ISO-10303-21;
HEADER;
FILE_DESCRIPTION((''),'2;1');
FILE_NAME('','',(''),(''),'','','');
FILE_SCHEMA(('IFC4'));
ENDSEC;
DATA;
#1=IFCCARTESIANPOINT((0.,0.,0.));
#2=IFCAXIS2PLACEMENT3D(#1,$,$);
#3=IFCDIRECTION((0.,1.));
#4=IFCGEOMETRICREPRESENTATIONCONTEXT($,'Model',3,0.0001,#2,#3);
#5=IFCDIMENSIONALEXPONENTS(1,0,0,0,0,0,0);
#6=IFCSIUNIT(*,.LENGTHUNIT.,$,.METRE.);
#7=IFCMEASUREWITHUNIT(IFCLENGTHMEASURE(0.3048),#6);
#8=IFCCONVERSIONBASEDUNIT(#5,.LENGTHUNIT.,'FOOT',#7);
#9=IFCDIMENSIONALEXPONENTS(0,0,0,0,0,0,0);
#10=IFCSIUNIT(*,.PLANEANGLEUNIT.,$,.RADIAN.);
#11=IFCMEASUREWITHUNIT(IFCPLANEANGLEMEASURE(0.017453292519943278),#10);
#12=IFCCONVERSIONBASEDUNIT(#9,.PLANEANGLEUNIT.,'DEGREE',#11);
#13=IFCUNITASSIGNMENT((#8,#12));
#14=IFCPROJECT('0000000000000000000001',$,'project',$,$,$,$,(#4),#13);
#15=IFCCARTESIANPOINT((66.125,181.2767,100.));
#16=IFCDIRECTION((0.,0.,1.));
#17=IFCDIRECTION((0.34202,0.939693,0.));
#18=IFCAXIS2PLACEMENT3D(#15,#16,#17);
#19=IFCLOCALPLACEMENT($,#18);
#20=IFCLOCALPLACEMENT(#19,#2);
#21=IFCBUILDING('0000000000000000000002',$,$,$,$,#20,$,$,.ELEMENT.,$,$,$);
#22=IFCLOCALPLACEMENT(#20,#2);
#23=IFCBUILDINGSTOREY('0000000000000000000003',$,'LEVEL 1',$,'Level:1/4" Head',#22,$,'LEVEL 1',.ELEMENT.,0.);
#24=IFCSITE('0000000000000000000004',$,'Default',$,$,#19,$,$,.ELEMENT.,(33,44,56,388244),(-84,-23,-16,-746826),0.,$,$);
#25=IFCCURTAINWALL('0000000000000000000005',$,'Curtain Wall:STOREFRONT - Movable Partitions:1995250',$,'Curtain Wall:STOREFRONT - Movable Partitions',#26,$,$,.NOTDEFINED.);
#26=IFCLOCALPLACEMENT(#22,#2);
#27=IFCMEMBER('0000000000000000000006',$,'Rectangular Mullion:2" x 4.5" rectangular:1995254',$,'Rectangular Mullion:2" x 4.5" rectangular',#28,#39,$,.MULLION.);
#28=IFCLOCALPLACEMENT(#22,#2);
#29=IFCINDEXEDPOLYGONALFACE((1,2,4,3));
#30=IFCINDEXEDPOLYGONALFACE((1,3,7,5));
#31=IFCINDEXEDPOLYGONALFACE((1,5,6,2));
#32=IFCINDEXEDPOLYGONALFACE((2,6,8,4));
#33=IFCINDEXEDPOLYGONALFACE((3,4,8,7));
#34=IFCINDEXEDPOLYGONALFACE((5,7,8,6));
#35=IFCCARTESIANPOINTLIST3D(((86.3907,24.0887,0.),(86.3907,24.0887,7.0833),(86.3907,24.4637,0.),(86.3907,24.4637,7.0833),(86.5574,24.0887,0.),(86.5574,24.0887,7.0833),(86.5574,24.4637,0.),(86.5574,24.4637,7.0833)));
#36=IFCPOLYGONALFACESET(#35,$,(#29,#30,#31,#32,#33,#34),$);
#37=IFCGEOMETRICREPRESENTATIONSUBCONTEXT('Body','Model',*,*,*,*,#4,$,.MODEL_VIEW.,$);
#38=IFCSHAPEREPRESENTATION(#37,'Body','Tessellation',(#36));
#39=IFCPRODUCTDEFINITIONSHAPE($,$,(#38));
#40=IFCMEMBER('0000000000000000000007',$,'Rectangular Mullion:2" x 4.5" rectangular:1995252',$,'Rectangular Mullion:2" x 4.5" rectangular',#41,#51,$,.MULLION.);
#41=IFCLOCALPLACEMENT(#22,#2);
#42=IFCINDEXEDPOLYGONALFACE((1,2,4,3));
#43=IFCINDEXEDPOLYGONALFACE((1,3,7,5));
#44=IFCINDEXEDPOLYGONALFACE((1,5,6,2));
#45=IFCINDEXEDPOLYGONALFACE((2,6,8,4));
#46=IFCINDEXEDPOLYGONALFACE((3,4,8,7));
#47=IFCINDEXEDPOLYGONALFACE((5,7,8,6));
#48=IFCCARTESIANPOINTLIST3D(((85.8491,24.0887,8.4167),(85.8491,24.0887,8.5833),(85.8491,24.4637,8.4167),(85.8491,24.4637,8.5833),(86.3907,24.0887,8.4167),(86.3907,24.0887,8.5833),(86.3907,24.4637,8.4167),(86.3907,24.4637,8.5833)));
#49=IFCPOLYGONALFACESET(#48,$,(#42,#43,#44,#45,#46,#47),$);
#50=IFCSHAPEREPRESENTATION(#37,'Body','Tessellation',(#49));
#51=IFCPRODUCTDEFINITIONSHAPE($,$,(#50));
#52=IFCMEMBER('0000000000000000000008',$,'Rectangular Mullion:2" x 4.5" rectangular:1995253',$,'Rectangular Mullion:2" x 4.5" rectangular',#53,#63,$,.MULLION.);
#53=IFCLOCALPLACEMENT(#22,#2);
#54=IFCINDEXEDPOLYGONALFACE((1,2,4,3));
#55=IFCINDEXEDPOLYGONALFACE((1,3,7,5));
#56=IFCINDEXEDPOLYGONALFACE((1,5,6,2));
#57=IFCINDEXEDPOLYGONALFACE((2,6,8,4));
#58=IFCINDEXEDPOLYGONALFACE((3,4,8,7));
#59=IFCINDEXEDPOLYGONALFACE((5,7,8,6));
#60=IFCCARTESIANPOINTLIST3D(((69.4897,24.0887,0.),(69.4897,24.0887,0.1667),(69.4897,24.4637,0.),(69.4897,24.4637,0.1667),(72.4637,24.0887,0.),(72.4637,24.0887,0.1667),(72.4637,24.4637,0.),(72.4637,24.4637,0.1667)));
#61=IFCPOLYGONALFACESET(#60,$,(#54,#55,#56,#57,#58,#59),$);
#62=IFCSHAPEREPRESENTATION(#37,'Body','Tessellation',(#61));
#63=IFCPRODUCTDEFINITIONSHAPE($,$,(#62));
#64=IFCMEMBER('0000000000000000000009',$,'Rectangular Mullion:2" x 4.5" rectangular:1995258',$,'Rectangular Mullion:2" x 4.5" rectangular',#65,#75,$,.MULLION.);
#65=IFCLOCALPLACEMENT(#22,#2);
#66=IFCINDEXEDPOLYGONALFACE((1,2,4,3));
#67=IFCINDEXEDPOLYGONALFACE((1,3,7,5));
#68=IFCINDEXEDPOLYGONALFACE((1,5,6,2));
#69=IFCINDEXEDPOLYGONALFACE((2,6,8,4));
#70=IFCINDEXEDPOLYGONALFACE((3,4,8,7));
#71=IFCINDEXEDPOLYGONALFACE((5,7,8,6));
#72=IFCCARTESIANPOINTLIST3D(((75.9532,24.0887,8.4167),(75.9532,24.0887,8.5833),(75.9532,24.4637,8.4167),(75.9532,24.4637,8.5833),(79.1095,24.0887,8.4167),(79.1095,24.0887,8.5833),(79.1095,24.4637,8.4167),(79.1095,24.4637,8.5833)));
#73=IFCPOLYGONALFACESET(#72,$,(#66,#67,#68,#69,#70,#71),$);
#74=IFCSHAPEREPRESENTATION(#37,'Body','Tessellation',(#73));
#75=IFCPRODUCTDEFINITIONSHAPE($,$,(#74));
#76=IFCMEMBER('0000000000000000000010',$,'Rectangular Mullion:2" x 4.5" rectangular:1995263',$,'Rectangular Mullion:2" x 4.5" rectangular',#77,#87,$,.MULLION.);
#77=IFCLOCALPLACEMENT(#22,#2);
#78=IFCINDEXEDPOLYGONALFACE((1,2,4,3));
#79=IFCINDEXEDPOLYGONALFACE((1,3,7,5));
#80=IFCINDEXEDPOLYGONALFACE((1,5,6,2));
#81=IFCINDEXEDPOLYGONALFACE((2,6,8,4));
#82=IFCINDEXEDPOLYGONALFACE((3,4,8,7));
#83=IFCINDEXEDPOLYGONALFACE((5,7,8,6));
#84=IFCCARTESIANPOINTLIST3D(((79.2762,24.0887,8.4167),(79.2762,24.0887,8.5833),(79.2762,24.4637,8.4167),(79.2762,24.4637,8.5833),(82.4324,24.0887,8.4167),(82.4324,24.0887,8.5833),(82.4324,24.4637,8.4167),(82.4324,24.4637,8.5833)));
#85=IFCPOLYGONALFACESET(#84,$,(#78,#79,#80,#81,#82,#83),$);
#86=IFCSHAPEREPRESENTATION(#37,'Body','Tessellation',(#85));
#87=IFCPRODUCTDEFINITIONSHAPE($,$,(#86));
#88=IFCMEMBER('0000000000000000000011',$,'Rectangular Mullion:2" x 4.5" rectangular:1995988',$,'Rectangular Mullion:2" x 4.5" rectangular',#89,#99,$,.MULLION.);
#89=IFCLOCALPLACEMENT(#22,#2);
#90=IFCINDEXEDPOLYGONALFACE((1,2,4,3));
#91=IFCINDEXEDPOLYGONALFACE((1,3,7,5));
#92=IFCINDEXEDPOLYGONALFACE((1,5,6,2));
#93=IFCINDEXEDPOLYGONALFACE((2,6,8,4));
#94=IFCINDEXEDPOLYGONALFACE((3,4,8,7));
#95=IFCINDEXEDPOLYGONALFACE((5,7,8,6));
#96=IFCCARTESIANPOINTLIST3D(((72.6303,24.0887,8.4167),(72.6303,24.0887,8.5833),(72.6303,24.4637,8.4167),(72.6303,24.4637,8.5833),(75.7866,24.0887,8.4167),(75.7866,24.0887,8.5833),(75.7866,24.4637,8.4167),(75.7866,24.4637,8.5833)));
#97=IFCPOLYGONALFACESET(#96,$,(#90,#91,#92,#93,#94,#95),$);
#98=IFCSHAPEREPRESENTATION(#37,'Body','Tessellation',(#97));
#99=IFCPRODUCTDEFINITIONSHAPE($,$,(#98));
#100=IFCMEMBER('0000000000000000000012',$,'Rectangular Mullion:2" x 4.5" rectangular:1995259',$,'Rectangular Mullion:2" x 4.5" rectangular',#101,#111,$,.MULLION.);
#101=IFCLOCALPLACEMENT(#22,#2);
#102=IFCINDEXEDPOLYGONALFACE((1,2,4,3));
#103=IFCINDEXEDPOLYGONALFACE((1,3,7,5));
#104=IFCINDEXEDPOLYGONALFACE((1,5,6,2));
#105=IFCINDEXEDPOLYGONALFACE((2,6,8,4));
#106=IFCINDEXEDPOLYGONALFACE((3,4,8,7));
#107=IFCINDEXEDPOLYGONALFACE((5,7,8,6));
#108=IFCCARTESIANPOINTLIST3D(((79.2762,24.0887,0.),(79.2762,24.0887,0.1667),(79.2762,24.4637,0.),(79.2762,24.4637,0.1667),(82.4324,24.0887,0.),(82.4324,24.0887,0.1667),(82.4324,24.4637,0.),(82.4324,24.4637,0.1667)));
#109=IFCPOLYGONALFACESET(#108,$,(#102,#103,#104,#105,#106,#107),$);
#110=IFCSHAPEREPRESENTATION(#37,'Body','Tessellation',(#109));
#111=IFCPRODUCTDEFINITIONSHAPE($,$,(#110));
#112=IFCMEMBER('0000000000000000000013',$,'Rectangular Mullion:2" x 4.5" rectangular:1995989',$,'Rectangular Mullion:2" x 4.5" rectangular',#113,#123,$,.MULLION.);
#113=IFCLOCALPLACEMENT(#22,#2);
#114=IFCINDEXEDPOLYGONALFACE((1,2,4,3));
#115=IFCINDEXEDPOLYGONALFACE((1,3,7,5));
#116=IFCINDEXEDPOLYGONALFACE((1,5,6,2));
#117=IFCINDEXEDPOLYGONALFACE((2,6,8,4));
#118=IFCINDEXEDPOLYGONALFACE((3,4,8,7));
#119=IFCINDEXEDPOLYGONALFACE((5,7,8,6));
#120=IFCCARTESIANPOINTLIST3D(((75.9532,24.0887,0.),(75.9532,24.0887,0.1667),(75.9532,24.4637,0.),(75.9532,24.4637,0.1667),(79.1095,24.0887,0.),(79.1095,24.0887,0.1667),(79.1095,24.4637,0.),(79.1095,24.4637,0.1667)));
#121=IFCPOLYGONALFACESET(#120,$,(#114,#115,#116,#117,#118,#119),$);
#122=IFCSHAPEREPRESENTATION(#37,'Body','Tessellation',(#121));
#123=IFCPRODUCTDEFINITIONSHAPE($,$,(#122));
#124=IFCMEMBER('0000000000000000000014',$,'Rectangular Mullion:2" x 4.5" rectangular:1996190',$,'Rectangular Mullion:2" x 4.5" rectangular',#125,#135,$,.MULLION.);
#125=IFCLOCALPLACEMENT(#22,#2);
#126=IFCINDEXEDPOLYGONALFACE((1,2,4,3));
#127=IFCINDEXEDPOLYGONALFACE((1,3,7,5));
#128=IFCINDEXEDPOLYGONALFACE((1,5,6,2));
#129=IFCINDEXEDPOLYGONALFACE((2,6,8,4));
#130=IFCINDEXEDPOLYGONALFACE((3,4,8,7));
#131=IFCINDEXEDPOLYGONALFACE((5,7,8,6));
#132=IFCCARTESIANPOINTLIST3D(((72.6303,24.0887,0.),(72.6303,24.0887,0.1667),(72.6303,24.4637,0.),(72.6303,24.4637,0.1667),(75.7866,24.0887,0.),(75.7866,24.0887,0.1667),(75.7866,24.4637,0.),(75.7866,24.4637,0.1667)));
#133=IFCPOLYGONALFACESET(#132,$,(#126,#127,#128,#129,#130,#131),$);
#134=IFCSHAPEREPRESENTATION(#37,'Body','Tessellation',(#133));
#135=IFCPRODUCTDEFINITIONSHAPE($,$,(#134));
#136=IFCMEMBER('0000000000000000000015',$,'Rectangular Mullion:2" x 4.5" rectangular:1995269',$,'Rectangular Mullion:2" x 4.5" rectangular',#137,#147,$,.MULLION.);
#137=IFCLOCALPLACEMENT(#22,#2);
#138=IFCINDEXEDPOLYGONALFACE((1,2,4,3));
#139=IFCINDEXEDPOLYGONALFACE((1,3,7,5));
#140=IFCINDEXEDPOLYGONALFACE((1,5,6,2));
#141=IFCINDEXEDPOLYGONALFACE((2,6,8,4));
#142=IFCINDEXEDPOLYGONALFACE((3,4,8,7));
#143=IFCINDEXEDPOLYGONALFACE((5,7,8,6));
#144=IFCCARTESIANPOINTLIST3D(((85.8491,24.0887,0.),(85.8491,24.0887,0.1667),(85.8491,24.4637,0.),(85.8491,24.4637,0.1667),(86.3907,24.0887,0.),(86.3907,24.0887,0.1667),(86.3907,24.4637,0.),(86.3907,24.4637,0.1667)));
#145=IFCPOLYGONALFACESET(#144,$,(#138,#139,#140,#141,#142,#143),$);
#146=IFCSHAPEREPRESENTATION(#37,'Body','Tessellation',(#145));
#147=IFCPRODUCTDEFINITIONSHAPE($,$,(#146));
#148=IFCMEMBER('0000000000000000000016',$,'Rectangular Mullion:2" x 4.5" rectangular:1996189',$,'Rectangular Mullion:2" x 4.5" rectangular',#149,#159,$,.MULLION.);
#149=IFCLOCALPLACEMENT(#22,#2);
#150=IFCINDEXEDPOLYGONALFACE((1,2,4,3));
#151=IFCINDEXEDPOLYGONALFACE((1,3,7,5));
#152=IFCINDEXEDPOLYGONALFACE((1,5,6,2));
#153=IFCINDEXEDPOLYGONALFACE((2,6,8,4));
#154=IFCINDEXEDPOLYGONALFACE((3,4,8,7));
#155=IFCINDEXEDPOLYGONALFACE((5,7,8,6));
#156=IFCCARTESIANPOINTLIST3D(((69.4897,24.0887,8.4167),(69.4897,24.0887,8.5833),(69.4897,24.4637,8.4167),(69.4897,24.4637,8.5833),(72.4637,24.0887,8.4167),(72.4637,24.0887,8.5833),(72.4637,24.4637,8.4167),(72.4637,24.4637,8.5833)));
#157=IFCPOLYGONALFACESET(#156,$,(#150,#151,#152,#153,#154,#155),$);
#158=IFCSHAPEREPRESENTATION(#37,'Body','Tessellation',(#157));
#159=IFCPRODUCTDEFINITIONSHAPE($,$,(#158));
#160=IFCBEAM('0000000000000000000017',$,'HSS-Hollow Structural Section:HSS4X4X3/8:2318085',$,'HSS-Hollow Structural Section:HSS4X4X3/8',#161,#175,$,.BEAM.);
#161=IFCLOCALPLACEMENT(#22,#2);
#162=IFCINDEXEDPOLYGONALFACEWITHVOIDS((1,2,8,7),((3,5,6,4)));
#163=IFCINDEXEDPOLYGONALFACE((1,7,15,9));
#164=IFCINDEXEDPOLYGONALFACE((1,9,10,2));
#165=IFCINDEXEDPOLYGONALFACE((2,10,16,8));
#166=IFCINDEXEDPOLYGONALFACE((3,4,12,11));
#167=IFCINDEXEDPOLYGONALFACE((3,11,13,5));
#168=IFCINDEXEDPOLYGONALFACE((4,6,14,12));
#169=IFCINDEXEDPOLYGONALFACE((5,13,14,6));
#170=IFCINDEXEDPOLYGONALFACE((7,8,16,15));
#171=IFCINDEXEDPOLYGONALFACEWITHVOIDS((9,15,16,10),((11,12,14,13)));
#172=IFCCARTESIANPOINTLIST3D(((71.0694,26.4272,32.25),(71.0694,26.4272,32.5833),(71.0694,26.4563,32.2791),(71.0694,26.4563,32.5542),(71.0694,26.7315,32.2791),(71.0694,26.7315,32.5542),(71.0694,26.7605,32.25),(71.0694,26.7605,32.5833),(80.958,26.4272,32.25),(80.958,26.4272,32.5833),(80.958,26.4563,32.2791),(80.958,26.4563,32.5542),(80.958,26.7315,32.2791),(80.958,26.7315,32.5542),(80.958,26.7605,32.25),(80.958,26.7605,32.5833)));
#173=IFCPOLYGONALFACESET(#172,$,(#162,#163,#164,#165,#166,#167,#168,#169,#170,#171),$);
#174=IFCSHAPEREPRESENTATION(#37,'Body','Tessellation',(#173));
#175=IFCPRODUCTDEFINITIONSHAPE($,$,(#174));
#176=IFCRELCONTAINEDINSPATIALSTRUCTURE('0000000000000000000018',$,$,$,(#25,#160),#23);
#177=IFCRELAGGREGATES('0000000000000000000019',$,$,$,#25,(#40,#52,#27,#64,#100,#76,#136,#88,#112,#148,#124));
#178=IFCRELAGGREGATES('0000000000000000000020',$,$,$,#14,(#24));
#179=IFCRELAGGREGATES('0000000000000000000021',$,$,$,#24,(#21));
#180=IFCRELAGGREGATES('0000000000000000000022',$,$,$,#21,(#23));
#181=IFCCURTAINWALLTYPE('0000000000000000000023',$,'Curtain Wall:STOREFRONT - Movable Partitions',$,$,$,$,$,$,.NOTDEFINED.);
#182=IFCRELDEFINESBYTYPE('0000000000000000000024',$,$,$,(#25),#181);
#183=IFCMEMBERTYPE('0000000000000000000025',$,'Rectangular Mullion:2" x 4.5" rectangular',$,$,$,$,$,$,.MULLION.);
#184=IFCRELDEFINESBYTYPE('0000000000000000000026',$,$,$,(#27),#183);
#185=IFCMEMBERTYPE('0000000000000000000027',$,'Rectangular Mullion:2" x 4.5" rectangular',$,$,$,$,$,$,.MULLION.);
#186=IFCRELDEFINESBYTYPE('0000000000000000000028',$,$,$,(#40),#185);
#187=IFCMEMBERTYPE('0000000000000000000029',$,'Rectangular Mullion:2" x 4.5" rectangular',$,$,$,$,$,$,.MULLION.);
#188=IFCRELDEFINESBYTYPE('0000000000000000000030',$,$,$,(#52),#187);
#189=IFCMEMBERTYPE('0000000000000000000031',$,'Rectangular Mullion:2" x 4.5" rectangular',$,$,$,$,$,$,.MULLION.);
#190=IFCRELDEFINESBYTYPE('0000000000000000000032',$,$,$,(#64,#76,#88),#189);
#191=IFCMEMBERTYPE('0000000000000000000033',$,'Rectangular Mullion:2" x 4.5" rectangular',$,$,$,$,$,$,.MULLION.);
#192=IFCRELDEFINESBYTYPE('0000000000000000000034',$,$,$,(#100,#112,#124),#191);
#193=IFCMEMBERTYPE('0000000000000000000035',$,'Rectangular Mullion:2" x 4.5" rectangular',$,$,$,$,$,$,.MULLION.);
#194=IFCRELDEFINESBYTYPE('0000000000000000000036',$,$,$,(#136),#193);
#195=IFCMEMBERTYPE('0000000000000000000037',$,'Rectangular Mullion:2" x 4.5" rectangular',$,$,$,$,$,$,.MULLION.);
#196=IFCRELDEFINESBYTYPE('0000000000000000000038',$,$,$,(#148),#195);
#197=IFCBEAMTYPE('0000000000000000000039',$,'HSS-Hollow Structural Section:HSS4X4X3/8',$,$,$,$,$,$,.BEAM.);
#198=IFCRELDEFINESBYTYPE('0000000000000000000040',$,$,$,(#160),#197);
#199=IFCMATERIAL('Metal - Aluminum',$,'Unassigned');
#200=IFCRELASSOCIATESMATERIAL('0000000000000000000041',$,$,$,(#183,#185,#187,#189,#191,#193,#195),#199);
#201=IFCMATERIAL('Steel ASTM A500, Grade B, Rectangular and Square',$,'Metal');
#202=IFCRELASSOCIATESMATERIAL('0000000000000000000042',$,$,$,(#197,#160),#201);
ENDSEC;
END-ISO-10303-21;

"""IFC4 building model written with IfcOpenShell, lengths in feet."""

from ifc_helpers import new_model, entity, si_unit, converted_unit, direction, frame, frame_2d, origin, origin_2d_with_axis, place, context, subcontext, project, spatial, rectangle, extrude, boolean, source, transform, mapped, material, material_profile, profile_set, type_object, type_shapes, element, aggregate, save


model = new_model("IFC4")

# Units and contexts
model_context = context("Model", 3, precision=0.0001, world=origin(), true_north=direction((0.0, 1.0)))
body_context = subcontext(model_context, "Body", "Model", "MODEL_VIEW")
ifc_project = project(units=[converted_unit("LENGTHUNIT", "FOOT", entity("IfcLengthMeasure", 0.3048), si_unit("LENGTHUNIT", "METRE"), dimensions=[1, 0, 0, 0, 0, 0, 0]), converted_unit("PLANEANGLEUNIT", "DEGREE", entity("IfcPlaneAngleMeasure", 0.017453292519943278), si_unit("PLANEANGLEUNIT", "RADIAN"), dimensions=[0, 0, 0, 0, 0, 0, 0])], contexts=[model_context])

# Site, building, storey
site_placement = place(None, frame((66.125, 181.2767, 100.0), z_axis=(0.0, 0.0, 1.0), x_axis=(0.34202, 0.939693, 0.0)))
site = spatial("IfcSite", under=ifc_project, at=site_placement, Name="Default", CompositionType="ELEMENT", RefLatitude=(33, 44, 56, 388244), RefLongitude=(-84, -23, -16, -746826), RefElevation=0.0)
building_placement = place(site_placement, origin())
building = spatial("IfcBuilding", under=site, at=building_placement, CompositionType="ELEMENT")
storey_placement = place(building_placement, origin())
storey = spatial("IfcBuildingStorey", under=building, at=storey_placement, Name="LEVEL 1", ObjectType="Level:1/4\" Head", LongName="LEVEL 1", CompositionType="ELEMENT", Elevation=0.0)

# Curtain wall, members
curtain_wall_type = type_object("IfcCurtainWallType", Name="Curtain Wall:STOREFRONT - Movable Partitions", PredefinedType="NOTDEFINED")
curtain_wall_1_placement = place(storey_placement, origin())
curtain_wall_1 = element("IfcCurtainWall", 1, at=curtain_wall_1_placement, inside=storey, type_object=curtain_wall_type, Name="Curtain Wall:STOREFRONT - Movable Partitions:1995250", ObjectType="Curtain Wall:STOREFRONT - Movable Partitions", PredefinedType="NOTDEFINED")
ifc_material_1 = material(Name="Metal - Aluminum", Category="Unassigned")
ifc_material_profile_1 = material_profile(ifc_material_1, rectangle(XDim=0.1667, YDim=0.375, at=origin_2d_with_axis()), Name="2\" x 4.5\" rectangular")
ifc_profile_set_1 = profile_set([ifc_material_profile_1], Name="2\" x 4.5\" rectangular")
member_type_1 = type_object("IfcMemberType", Name="Rectangular Mullion:2\" x 4.5\" rectangular", PredefinedType="MULLION", material=ifc_profile_set_1)
shared_shape_1 = source(origin(), body_context, "Body", "SweptSolid", [
    extrude(rectangle(XDim=0.1667, YDim=0.375, at=origin_2d_with_axis()), frame((-0.0833, 0.0, -7.0833), z_axis=(0.0, 0.0, 1.0), x_axis=(-1.0, 0.0, 0.0)), (0.0, 0.0, 1.0), 7.0833),
])
type_shapes(member_type_1, [shared_shape_1])
member_1_placement = place(curtain_wall_1_placement, frame((86.5574, 24.2762, 0.0), z_axis=(0.0, 0.0, -1.0), x_axis=(1.0, 0.0, 0.0)))
member_1 = element("IfcMember", 2, at=member_1_placement, type_object=member_type_1, Name="Rectangular Mullion:2\" x 4.5\" rectangular:1995254", ObjectType="Rectangular Mullion:2\" x 4.5\" rectangular", PredefinedType="MULLION", context=body_context, shape_type="MappedRepresentation", body=[
    mapped(shared_shape_1, transform((0.0, 0.0, 0.0), scale=1.0)),
])
member_type_2 = type_object("IfcMemberType", Name="Rectangular Mullion:2\" x 4.5\" rectangular", PredefinedType="MULLION", material=ifc_profile_set_1)
shared_shape_2 = source(origin(), body_context, "Body", "SweptSolid", [
    extrude(rectangle(XDim=0.1667, YDim=0.375, at=origin_2d_with_axis()), frame((-0.0833, 0.0, -0.5417), z_axis=(0.0, 0.0, 1.0), x_axis=(-1.0, 0.0, 0.0)), (0.0, 0.0, 1.0), 0.5417),
])
type_shapes(member_type_2, [shared_shape_2])
member_2_placement = place(curtain_wall_1_placement, frame((86.3907, 24.2762, 8.5833), z_axis=(1.0, 0.0, 0.0), x_axis=(0.0, 0.0, 1.0)))
member_2 = element("IfcMember", 3, at=member_2_placement, type_object=member_type_2, Name="Rectangular Mullion:2\" x 4.5\" rectangular:1995252", ObjectType="Rectangular Mullion:2\" x 4.5\" rectangular", PredefinedType="MULLION", context=body_context, shape_type="MappedRepresentation", body=[
    mapped(shared_shape_2, transform((0.0, 0.0, 0.0), scale=1.0)),
])
member_type_3 = type_object("IfcMemberType", Name="Rectangular Mullion:2\" x 4.5\" rectangular", PredefinedType="MULLION", material=ifc_profile_set_1)
shared_shape_3 = source(origin(), body_context, "Body", "SweptSolid", [
    extrude(rectangle(XDim=0.1667, YDim=0.375, at=origin_2d_with_axis()), frame((-0.0833, 0.0, -2.974), z_axis=(0.0, 0.0, 1.0), x_axis=(-1.0, 0.0, 0.0)), (0.0, 0.0, 1.0), 2.974),
])
type_shapes(member_type_3, [shared_shape_3])
member_3_placement = place(curtain_wall_1_placement, frame((69.4897, 24.2762, 0.0), z_axis=(-1.0, 0.0, 0.0), x_axis=(0.0, 0.0, -1.0)))
member_3 = element("IfcMember", 4, at=member_3_placement, type_object=member_type_3, Name="Rectangular Mullion:2\" x 4.5\" rectangular:1995253", ObjectType="Rectangular Mullion:2\" x 4.5\" rectangular", PredefinedType="MULLION", context=body_context, shape_type="MappedRepresentation", body=[
    mapped(shared_shape_3, transform((0.0, 0.0, 0.0), scale=1.0)),
])
member_type_4 = type_object("IfcMemberType", Name="Rectangular Mullion:2\" x 4.5\" rectangular", PredefinedType="MULLION", material=ifc_profile_set_1)
shared_shape_4 = source(origin(), body_context, "Body", "SweptSolid", [
    extrude(rectangle(XDim=0.1667, YDim=0.375, at=origin_2d_with_axis()), frame((-0.0833, 0.0, -3.1563), z_axis=(0.0, 0.0, 1.0), x_axis=(-1.0, 0.0, 0.0)), (0.0, 0.0, 1.0), 3.1563),
])
type_shapes(member_type_4, [shared_shape_4])
member_4_placement = place(curtain_wall_1_placement, frame((79.1095, 24.2762, 8.5833), z_axis=(1.0, 0.0, 0.0), x_axis=(0.0, 0.0, 1.0)))
member_4 = element("IfcMember", 5, at=member_4_placement, type_object=member_type_4, Name="Rectangular Mullion:2\" x 4.5\" rectangular:1995258", ObjectType="Rectangular Mullion:2\" x 4.5\" rectangular", PredefinedType="MULLION", context=body_context, shape_type="MappedRepresentation", body=[
    mapped(shared_shape_4, transform((0.0, 0.0, 0.0), scale=1.0)),
])
member_5_placement = place(curtain_wall_1_placement, frame((82.4324, 24.2762, 8.5833), z_axis=(1.0, 0.0, 0.0), x_axis=(0.0, 0.0, 1.0)))
member_5 = element("IfcMember", 6, at=member_5_placement, type_object=member_type_4, Name="Rectangular Mullion:2\" x 4.5\" rectangular:1995263", ObjectType="Rectangular Mullion:2\" x 4.5\" rectangular", PredefinedType="MULLION", context=body_context, shape_type="MappedRepresentation", body=[
    mapped(shared_shape_4, transform((0.0, 0.0, 0.0), scale=1.0)),
])
member_6_placement = place(curtain_wall_1_placement, frame((75.7866, 24.2762, 8.5833), z_axis=(1.0, 0.0, 0.0), x_axis=(0.0, 0.0, 1.0)))
member_6 = element("IfcMember", 7, at=member_6_placement, type_object=member_type_4, Name="Rectangular Mullion:2\" x 4.5\" rectangular:1995988", ObjectType="Rectangular Mullion:2\" x 4.5\" rectangular", PredefinedType="MULLION", context=body_context, shape_type="MappedRepresentation", body=[
    mapped(shared_shape_4, transform((0.0, 0.0, 0.0), scale=1.0)),
])
member_type_5 = type_object("IfcMemberType", Name="Rectangular Mullion:2\" x 4.5\" rectangular", PredefinedType="MULLION", material=ifc_profile_set_1)
shared_shape_5 = source(origin(), body_context, "Body", "SweptSolid", [
    extrude(rectangle(XDim=0.1667, YDim=0.375, at=origin_2d_with_axis()), frame((-0.0833, 0.0, -3.1563), z_axis=(0.0, 0.0, 1.0), x_axis=(-1.0, 0.0, 0.0)), (0.0, 0.0, 1.0), 3.1563),
])
type_shapes(member_type_5, [shared_shape_5])
member_7_placement = place(curtain_wall_1_placement, frame((79.2762, 24.2762, 0.0), z_axis=(-1.0, 0.0, 0.0), x_axis=(0.0, 0.0, -1.0)))
member_7 = element("IfcMember", 8, at=member_7_placement, type_object=member_type_5, Name="Rectangular Mullion:2\" x 4.5\" rectangular:1995259", ObjectType="Rectangular Mullion:2\" x 4.5\" rectangular", PredefinedType="MULLION", context=body_context, shape_type="MappedRepresentation", body=[
    mapped(shared_shape_5, transform((0.0, 0.0, 0.0), scale=1.0)),
])
member_8_placement = place(curtain_wall_1_placement, frame((75.9532, 24.2762, 0.0), z_axis=(-1.0, 0.0, 0.0), x_axis=(0.0, 0.0, -1.0)))
member_8 = element("IfcMember", 9, at=member_8_placement, type_object=member_type_5, Name="Rectangular Mullion:2\" x 4.5\" rectangular:1995989", ObjectType="Rectangular Mullion:2\" x 4.5\" rectangular", PredefinedType="MULLION", context=body_context, shape_type="MappedRepresentation", body=[
    mapped(shared_shape_5, transform((0.0, 0.0, 0.0), scale=1.0)),
])
member_9_placement = place(curtain_wall_1_placement, frame((72.6303, 24.2762, 0.0), z_axis=(-1.0, 0.0, 0.0), x_axis=(0.0, 0.0, -1.0)))
member_9 = element("IfcMember", 10, at=member_9_placement, type_object=member_type_5, Name="Rectangular Mullion:2\" x 4.5\" rectangular:1996190", ObjectType="Rectangular Mullion:2\" x 4.5\" rectangular", PredefinedType="MULLION", context=body_context, shape_type="MappedRepresentation", body=[
    mapped(shared_shape_5, transform((0.0, 0.0, 0.0), scale=1.0)),
])
member_type_6 = type_object("IfcMemberType", Name="Rectangular Mullion:2\" x 4.5\" rectangular", PredefinedType="MULLION", material=ifc_profile_set_1)
shared_shape_6 = source(origin(), body_context, "Body", "SweptSolid", [
    extrude(rectangle(XDim=0.1667, YDim=0.375, at=origin_2d_with_axis()), frame((-0.0833, 0.0, -0.5417), z_axis=(0.0, 0.0, 1.0), x_axis=(-1.0, 0.0, 0.0)), (0.0, 0.0, 1.0), 0.5417),
])
type_shapes(member_type_6, [shared_shape_6])
member_10_placement = place(curtain_wall_1_placement, frame((85.8491, 24.2762, 0.0), z_axis=(-1.0, 0.0, 0.0), x_axis=(0.0, 0.0, -1.0)))
member_10 = element("IfcMember", 11, at=member_10_placement, type_object=member_type_6, Name="Rectangular Mullion:2\" x 4.5\" rectangular:1995269", ObjectType="Rectangular Mullion:2\" x 4.5\" rectangular", PredefinedType="MULLION", context=body_context, shape_type="MappedRepresentation", body=[
    mapped(shared_shape_6, transform((0.0, 0.0, 0.0), scale=1.0)),
])
member_type_7 = type_object("IfcMemberType", Name="Rectangular Mullion:2\" x 4.5\" rectangular", PredefinedType="MULLION", material=ifc_profile_set_1)
shared_shape_7 = source(origin(), body_context, "Body", "SweptSolid", [
    extrude(rectangle(XDim=0.1667, YDim=0.375, at=origin_2d_with_axis()), frame((-0.0833, 0.0, -2.974), z_axis=(0.0, 0.0, 1.0), x_axis=(-1.0, 0.0, 0.0)), (0.0, 0.0, 1.0), 2.974),
])
type_shapes(member_type_7, [shared_shape_7])
member_11_placement = place(curtain_wall_1_placement, frame((72.4637, 24.2762, 8.5833), z_axis=(1.0, 0.0, 0.0), x_axis=(0.0, 0.0, 1.0)))
member_11 = element("IfcMember", 12, at=member_11_placement, type_object=member_type_7, Name="Rectangular Mullion:2\" x 4.5\" rectangular:1996189", ObjectType="Rectangular Mullion:2\" x 4.5\" rectangular", PredefinedType="MULLION", context=body_context, shape_type="MappedRepresentation", body=[
    mapped(shared_shape_7, transform((0.0, 0.0, 0.0), scale=1.0)),
])

# Beam
ifc_material_2 = material(Name="Steel ASTM A500, Grade B, Rectangular and Square", Category="Metal")
ifc_material_profile_2 = material_profile(ifc_material_2, rectangle(XDim=0.3333, YDim=0.3333, at=origin_2d_with_axis()), Name="HSS4X4X3/8")
ifc_profile_set_2 = profile_set([ifc_material_profile_2], Name="HSS4X4X3/8")
beam_type_1 = type_object("IfcBeamType", Name="HSS-Hollow Structural Section:HSS4X4X3/8", PredefinedType="BEAM", material=ifc_profile_set_2)
shared_shape_8 = source(origin(), body_context, "Body", "SweptSolid", [
    boolean("DIFFERENCE", extrude(rectangle(XDim=0.3333, YDim=0.3333, at=origin_2d_with_axis()), frame((-4.9443, 0.0, 0.0), z_axis=(1.0, 0.0, 0.0), x_axis=(0.0, 0.0, -1.0)), (0.0, 0.0, 1.0), 9.8886), extrude(rectangle(XDim=0.2752, YDim=0.2752, at=frame_2d((0.0, 0.0), x_axis=(0.0, 1.0))), frame((4.9443, 0.0, 0.0), z_axis=(-1.0, 0.0, 0.0), x_axis=(0.0, 1.0, 0.0)), (0.0, 0.0, 1.0), 9.8886)),
])
type_shapes(beam_type_1, [shared_shape_8])
for number, where, name in (
    (13, (76.0137, 26.5939, 32.4167), "HSS-Hollow Structural Section:HSS4X4X3/8:2318085"),
):
    element("IfcBeam", number, at=place(storey_placement, frame(where)), inside=storey, type_object=beam_type_1, material=ifc_material_2, Name=name, ObjectType="HSS-Hollow Structural Section:HSS4X4X3/8", PredefinedType="BEAM", context=body_context, shape_type="MappedRepresentation", body=[
        mapped(shared_shape_8, transform((0.0, 0.0, 0.0), scale=1.0)),
    ])

aggregate(curtain_wall_1, [member_2, member_3, member_1, member_4, member_7, member_5, member_10, member_6, member_8, member_11, member_9])

save(model, "model.ifc")
